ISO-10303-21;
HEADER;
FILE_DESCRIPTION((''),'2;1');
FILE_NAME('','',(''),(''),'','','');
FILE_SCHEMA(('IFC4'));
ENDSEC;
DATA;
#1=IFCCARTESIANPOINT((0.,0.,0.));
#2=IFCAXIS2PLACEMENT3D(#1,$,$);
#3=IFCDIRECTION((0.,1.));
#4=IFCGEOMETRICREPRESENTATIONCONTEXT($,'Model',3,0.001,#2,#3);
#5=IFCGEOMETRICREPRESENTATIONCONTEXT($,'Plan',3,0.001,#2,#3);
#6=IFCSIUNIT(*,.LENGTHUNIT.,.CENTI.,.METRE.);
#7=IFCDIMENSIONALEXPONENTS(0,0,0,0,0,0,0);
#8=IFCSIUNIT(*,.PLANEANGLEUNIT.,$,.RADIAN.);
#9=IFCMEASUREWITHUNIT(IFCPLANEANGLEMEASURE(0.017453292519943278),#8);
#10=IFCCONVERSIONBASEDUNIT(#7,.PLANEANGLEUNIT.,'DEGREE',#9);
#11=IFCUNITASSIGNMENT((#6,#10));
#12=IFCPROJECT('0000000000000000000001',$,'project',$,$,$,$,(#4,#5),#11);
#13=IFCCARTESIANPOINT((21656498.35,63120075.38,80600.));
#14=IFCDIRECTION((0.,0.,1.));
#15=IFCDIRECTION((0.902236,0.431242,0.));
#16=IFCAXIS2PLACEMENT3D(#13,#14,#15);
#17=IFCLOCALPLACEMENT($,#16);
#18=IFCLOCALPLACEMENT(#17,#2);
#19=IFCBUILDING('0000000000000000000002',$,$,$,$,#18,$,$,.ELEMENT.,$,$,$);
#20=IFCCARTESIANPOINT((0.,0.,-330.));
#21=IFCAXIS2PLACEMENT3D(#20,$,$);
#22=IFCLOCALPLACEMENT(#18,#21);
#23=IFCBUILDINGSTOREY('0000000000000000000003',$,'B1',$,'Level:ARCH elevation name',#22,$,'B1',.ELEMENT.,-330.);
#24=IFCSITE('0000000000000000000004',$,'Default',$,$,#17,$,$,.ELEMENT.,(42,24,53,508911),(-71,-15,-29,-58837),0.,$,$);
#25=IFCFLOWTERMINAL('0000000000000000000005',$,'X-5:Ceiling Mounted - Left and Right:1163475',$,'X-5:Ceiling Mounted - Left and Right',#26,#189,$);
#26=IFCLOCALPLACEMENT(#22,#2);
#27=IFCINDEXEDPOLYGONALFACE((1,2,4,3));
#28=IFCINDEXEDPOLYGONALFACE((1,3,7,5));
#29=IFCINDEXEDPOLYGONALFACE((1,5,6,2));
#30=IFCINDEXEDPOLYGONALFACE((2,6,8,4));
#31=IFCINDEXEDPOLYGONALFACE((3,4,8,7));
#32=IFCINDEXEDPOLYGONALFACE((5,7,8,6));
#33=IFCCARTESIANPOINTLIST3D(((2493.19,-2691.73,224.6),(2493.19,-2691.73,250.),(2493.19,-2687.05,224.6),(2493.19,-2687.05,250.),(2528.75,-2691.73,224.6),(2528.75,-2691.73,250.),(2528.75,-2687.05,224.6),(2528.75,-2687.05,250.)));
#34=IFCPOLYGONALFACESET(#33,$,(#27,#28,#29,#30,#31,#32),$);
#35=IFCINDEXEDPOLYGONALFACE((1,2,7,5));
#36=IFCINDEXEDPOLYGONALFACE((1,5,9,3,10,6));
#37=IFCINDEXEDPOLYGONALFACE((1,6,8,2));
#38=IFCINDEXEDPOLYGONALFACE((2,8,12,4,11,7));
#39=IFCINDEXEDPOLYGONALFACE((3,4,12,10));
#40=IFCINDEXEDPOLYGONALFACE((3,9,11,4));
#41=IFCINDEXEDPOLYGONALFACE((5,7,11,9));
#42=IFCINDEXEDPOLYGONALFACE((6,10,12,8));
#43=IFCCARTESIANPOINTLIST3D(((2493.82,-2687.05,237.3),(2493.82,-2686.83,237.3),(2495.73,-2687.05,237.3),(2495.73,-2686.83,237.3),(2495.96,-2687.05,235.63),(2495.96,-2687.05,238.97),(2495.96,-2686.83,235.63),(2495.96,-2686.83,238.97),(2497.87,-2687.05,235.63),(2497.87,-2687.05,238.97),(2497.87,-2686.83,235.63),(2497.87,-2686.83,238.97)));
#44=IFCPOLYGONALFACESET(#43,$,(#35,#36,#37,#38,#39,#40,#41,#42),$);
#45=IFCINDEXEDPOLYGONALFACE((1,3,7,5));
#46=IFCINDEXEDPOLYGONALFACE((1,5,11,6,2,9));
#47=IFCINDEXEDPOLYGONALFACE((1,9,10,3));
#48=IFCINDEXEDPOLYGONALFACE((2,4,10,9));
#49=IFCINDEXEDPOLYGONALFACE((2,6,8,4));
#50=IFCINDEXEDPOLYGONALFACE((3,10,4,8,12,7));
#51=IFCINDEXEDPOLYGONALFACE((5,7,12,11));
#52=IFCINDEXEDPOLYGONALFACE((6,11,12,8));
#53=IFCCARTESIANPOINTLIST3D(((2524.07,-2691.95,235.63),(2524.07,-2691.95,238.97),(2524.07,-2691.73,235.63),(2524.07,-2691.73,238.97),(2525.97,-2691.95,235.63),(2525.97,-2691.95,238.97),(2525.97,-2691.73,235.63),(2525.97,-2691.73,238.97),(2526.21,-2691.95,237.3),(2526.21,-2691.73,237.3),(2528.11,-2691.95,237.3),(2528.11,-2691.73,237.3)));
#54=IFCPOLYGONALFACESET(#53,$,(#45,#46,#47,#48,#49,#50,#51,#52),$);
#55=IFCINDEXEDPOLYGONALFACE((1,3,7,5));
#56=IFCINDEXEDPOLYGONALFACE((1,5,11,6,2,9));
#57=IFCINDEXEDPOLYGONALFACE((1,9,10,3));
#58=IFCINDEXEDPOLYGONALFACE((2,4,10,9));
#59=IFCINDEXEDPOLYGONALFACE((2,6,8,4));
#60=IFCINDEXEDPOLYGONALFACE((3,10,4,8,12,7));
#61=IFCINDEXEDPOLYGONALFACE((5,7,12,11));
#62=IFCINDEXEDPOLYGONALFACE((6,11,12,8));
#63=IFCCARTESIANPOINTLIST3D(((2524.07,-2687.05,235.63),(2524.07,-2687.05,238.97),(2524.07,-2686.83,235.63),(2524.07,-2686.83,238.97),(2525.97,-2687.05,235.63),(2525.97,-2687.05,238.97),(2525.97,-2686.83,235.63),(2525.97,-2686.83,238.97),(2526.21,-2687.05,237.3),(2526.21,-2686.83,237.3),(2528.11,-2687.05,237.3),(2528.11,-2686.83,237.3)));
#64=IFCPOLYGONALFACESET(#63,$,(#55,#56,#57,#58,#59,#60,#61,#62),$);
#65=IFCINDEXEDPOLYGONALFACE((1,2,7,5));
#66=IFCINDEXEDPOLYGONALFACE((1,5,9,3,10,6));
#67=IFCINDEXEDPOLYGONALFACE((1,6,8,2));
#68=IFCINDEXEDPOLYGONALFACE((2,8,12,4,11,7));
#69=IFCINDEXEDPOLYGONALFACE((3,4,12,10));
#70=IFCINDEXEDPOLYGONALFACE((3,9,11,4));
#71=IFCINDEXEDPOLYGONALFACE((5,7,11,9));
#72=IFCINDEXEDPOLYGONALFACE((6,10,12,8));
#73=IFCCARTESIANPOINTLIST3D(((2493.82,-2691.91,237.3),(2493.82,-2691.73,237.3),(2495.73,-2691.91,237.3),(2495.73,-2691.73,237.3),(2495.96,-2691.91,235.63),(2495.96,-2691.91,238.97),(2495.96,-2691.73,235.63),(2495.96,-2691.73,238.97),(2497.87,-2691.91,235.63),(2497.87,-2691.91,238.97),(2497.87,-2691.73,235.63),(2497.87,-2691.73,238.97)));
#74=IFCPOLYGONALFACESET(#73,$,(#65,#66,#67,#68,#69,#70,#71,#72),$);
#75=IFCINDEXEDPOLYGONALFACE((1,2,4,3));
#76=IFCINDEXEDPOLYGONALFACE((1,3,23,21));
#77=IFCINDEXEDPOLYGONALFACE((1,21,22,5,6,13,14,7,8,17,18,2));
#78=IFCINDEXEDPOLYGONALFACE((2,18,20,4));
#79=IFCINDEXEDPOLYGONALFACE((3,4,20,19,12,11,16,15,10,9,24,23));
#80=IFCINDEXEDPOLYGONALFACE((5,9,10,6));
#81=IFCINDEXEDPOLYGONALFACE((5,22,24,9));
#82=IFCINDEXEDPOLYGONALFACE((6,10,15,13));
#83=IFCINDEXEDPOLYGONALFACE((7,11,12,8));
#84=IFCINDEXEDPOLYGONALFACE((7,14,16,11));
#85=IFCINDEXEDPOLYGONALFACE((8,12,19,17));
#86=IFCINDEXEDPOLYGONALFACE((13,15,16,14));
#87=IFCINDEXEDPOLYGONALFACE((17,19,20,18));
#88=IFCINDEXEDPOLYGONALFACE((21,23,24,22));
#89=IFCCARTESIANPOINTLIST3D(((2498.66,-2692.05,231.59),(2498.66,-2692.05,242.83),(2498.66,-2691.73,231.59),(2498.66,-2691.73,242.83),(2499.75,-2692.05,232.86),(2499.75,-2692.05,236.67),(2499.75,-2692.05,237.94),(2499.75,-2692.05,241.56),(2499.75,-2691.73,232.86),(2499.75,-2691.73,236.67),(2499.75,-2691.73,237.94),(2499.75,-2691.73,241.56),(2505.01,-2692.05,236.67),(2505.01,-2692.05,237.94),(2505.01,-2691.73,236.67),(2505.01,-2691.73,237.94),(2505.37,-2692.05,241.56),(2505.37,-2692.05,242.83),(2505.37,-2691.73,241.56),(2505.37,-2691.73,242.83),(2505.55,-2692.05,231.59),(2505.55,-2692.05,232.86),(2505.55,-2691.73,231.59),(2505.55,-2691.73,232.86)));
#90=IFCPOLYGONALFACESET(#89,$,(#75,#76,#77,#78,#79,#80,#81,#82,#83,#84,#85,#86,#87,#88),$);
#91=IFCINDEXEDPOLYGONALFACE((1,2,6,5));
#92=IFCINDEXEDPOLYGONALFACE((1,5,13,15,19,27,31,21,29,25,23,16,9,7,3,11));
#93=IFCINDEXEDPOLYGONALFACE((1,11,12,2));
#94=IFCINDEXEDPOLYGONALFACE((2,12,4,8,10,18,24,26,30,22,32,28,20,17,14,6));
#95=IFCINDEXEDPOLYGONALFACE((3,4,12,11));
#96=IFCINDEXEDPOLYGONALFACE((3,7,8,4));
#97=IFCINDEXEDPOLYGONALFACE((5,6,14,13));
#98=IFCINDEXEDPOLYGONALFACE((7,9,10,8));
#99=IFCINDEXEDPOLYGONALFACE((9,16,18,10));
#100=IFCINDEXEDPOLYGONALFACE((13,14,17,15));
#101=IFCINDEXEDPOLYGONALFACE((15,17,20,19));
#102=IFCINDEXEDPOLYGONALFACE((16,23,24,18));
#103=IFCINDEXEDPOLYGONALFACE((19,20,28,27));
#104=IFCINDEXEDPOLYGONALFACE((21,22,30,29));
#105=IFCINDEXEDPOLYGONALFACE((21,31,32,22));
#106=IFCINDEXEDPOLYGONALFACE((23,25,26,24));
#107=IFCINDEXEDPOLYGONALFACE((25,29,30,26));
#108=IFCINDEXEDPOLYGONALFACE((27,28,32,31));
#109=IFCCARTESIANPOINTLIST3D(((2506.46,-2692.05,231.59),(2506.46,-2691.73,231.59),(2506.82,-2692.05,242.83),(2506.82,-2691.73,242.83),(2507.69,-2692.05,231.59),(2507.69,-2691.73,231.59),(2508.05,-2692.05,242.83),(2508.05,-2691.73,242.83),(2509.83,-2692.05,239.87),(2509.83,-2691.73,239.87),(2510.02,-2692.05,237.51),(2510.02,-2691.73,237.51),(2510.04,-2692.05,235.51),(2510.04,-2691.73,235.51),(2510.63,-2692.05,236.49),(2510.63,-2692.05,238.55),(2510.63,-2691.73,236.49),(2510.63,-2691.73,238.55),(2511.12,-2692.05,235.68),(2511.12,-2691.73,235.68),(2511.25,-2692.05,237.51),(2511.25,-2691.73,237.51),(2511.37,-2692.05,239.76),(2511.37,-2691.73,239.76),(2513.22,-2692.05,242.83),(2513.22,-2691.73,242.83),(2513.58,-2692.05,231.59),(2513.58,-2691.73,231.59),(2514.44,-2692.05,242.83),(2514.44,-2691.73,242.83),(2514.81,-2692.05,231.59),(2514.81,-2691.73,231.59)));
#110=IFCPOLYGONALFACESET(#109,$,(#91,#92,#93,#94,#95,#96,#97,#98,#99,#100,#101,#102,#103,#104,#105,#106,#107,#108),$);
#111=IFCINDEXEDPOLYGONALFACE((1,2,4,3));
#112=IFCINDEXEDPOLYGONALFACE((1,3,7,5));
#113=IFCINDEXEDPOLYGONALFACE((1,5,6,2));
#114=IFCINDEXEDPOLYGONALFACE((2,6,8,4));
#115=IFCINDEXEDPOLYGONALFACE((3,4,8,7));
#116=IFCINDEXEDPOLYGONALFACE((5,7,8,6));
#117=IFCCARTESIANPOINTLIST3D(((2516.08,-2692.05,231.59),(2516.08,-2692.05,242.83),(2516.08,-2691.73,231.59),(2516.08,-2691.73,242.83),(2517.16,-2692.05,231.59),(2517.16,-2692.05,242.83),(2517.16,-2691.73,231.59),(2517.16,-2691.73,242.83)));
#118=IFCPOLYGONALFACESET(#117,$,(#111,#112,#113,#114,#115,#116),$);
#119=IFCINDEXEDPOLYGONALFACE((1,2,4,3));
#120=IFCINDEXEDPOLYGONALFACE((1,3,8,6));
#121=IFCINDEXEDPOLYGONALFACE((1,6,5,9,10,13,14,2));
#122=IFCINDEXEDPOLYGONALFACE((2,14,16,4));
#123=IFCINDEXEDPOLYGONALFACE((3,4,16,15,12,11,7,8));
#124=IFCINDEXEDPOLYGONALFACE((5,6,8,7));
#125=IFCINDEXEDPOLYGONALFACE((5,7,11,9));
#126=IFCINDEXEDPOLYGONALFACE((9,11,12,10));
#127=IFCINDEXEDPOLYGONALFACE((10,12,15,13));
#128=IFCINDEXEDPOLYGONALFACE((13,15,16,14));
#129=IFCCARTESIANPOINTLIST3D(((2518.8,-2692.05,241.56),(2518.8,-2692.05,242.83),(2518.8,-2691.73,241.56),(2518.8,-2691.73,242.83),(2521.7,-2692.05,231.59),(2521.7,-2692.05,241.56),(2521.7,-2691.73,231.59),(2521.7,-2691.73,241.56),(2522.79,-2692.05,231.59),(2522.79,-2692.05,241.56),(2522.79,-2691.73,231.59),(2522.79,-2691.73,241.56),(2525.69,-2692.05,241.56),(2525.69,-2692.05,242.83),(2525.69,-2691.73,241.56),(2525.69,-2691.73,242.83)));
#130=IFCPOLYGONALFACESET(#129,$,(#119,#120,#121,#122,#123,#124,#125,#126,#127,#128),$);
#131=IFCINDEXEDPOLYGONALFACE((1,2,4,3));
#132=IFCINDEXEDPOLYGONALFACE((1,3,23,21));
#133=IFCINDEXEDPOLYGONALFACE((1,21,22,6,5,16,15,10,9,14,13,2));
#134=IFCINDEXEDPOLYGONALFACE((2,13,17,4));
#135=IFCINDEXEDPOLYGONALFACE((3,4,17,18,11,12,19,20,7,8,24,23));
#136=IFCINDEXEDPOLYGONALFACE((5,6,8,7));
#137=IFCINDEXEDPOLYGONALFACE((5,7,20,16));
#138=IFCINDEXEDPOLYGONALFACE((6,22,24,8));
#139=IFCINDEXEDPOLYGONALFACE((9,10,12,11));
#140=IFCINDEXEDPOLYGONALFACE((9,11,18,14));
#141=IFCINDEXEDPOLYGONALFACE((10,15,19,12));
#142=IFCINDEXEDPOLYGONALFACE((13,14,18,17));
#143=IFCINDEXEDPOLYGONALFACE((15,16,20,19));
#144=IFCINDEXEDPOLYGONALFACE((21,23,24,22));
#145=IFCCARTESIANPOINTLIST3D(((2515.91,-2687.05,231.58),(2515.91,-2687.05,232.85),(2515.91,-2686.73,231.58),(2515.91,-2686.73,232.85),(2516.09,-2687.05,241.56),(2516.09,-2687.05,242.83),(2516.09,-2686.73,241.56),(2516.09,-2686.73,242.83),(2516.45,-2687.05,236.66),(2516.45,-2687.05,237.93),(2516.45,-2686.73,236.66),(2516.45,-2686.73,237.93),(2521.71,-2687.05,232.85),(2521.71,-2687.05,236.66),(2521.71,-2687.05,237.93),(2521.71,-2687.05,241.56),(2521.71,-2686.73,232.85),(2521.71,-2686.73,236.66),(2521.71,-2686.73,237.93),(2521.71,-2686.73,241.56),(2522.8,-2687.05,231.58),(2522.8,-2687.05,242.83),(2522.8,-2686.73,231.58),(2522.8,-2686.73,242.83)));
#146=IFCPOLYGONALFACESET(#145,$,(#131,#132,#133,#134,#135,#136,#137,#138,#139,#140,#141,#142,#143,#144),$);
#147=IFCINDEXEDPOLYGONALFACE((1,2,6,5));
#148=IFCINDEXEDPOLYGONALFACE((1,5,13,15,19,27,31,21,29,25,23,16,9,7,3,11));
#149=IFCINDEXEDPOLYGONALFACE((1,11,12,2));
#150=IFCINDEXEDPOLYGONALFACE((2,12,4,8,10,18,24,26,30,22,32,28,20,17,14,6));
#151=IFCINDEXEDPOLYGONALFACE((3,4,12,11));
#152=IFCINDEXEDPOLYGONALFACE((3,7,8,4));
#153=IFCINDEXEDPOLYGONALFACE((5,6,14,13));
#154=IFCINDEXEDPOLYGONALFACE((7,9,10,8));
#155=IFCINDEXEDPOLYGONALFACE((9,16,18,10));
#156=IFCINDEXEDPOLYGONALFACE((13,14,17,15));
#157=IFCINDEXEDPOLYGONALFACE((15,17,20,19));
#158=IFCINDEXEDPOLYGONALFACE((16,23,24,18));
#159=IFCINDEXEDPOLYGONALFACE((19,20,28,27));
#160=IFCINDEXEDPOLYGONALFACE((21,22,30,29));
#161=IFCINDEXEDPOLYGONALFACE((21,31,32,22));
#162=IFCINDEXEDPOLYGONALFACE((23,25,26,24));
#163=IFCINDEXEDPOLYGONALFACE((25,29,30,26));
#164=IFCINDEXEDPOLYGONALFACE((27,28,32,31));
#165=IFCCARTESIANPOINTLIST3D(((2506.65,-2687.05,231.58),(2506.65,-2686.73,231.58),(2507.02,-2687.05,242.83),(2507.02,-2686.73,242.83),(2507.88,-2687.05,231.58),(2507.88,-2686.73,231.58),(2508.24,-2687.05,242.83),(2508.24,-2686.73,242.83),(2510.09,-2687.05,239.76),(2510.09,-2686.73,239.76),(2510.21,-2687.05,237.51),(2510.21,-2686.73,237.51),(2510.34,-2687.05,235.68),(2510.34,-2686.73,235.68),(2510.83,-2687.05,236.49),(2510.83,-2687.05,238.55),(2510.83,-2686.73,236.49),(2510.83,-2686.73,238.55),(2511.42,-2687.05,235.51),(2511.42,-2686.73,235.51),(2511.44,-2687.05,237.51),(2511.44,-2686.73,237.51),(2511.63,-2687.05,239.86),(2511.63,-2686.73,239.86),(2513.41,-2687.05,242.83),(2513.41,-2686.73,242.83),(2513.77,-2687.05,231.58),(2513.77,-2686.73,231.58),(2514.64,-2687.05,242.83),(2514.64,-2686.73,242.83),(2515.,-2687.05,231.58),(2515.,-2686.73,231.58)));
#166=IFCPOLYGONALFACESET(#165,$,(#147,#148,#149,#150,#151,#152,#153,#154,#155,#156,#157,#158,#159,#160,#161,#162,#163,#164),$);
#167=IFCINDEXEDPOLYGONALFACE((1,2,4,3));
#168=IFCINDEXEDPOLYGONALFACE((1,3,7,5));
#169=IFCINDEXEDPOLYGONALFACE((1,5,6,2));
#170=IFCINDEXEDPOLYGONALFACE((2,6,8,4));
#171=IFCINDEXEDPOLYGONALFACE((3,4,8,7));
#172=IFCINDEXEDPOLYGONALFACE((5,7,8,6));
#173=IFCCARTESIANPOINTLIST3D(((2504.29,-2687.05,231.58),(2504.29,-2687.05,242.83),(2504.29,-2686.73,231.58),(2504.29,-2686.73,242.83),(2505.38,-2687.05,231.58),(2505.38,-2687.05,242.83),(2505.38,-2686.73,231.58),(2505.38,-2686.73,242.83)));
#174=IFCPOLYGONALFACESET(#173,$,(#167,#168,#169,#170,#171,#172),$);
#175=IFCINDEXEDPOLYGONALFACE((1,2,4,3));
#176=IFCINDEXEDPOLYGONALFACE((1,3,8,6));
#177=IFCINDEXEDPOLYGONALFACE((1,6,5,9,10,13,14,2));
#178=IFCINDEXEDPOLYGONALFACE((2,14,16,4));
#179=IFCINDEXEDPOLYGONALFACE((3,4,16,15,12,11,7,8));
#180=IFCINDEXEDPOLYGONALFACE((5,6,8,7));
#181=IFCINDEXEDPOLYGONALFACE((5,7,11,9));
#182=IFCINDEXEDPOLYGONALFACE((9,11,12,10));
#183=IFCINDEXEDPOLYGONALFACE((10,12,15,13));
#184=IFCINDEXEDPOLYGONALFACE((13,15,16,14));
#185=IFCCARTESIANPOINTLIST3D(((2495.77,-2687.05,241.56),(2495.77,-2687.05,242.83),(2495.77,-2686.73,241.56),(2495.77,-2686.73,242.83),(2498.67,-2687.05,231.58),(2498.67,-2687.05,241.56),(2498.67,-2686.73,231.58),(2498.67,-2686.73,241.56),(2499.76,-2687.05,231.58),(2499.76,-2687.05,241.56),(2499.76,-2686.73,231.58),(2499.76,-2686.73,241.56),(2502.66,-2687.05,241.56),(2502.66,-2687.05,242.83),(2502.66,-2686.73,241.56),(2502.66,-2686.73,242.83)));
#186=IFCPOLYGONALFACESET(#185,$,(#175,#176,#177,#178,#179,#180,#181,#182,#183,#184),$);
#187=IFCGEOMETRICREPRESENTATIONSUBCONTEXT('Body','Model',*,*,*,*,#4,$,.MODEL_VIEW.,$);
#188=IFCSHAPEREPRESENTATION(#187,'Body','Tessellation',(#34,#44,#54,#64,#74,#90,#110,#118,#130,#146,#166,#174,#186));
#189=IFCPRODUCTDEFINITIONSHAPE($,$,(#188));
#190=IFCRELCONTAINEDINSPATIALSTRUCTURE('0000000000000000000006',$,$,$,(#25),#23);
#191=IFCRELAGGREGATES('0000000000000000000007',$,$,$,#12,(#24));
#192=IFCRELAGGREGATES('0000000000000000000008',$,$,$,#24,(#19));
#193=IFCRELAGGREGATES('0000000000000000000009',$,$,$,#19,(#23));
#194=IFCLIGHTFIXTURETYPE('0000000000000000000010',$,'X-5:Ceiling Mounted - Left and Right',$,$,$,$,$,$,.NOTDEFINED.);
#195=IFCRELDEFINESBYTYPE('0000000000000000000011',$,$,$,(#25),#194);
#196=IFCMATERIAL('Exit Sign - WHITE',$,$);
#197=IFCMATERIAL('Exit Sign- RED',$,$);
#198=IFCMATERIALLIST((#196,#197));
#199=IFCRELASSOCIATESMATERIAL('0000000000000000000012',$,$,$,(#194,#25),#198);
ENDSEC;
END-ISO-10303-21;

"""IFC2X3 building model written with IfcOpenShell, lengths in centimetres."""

from ifc_helpers import new_model, entity, si_unit, converted_unit, direction, frame, frame_2d, origin, place, context, subcontext, project, spatial, polyline, rectangle, outline, extrude, source, transform, mapped, material, material_list, type_object, type_shapes, element, save


model = new_model("IFC2X3")

# Units and contexts
model_context = context("Model", 3, precision=0.001, world=origin(), true_north=direction((0.0, 1.0)))
plan_context = context("Plan", 3, precision=0.001, world=origin(), true_north=direction((0.0, 1.0)))
body_context = subcontext(model_context, "Body", "Model", "MODEL_VIEW")
ifc_project = project(units=[si_unit("LENGTHUNIT", "METRE", prefix="CENTI"), converted_unit("PLANEANGLEUNIT", "DEGREE", entity("IfcPlaneAngleMeasure", 0.017453292519943278), si_unit("PLANEANGLEUNIT", "RADIAN"), dimensions=[0, 0, 0, 0, 0, 0, 0])], contexts=[model_context, plan_context])

# Site, building, storey
site_placement = place(None, frame((21656498.35, 63120075.38, 80600.0), z_axis=(0.0, 0.0, 1.0), x_axis=(0.902236, 0.431242, 0.0)))
site = spatial("IfcSite", under=ifc_project, at=site_placement, Name="Default", CompositionType="ELEMENT", RefLatitude=(42, 24, 53, 508911), RefLongitude=(-71, -15, -29, -58837), RefElevation=0.0)
building_placement = place(site_placement, origin())
building = spatial("IfcBuilding", under=site, at=building_placement, CompositionType="ELEMENT")
storey_placement = place(building_placement, frame((0.0, 0.0, -330.0)))
storey = spatial("IfcBuildingStorey", under=building, at=storey_placement, Name="B1", ObjectType="Level:ARCH elevation name", LongName="B1", CompositionType="ELEMENT", Elevation=-330.0)

# Flow terminal
ifc_material_1 = material(Name="Exit Sign - WHITE")
ifc_material_2 = material(Name="Exit Sign- RED")
ifc_material_list_1 = material_list([ifc_material_1, ifc_material_2])
light_fixture_type_1 = type_object("IfcLightFixtureType", Name="X-5:Ceiling Mounted - Left and Right", PredefinedType="NOTDEFINED", material=ifc_material_list_1)
shared_shape_1 = source(origin(), body_context, "Body", "SweptSolid", [
    extrude(rectangle(XDim=4.68, YDim=35.56, at=frame_2d((0.0, 0.0), x_axis=(1.0, 0.0))), frame((0.0, 1.02, -25.4), z_axis=(0.0, 0.0, 1.0), x_axis=(0.0, 1.0, 0.0)), (0.0, 0.0, 1.0), 25.4),
    extrude(outline(polyline([(-0.24, -1.67), (1.67, -1.67), (-0.47, 0.0), (1.67, 1.67), (-0.24, 1.67), (-2.38, 0.0), (-0.24, -1.67)])), frame((-14.77, 3.36, -12.7), z_axis=(0.0, 1.0, 0.0), x_axis=(1.0, 0.0, 0.0)), (0.0, 0.0, 1.0), 0.22),
    extrude(outline(polyline([(-0.84, -1.47), (1.88, -1.47), (1.22, 1.17), (-0.28, 2.34), (0.37, -0.29), (-2.34, -0.29), (-0.84, -1.47)])), frame((14.77, -1.54, -12.7), z_axis=(0.0, 1.0, 0.0), x_axis=(0.788011, 0.0, -0.615661)), (0.0, 0.0, 1.0), 0.22),
    extrude(outline(polyline([(-0.84, -1.47), (1.88, -1.47), (1.22, 1.17), (-0.28, 2.34), (0.37, -0.29), (-2.34, -0.29), (-0.84, -1.47)])), frame((14.77, 3.36, -12.7), z_axis=(0.0, 1.0, 0.0), x_axis=(0.788011, 0.0, -0.615661)), (0.0, 0.0, 1.0), 0.22),
    extrude(outline(polyline([(-0.24, -1.67), (1.67, -1.67), (-0.47, 0.0), (1.67, 1.67), (-0.24, 1.67), (-2.38, 0.0), (-0.24, -1.67)])), frame((-14.77, -1.49, -12.7), z_axis=(0.0, 1.0, 0.0), x_axis=(1.0, 0.0, 0.0)), (0.0, 0.0, 1.0), 0.18),
    extrude(outline(polyline([(-5.65, -3.69), (5.59, -3.69), (5.59, 3.02), (4.32, 3.02), (4.32, -2.6), (0.7, -2.6), (0.7, 2.66), (-0.57, 2.66), (-0.57, -2.6), (-4.38, -2.6), (-4.38, 3.21), (-5.65, 3.21), (-5.65, -3.69)])), frame((-8.62, -1.63, -12.76), z_axis=(0.0, 1.0, 0.0), x_axis=(0.0, 0.0, 1.0)), (0.0, 0.0, 1.0), 0.32),
    extrude(outline(polyline([(-7.14, 0.57), (-6.5, -0.49), (-1.93, -0.48), (-0.78, -0.48), (-1.23, -1.32), (-3.47, -5.53), (-2.84, -6.59), (0.41, -0.48), (6.62, -0.48), (5.99, 0.57), (2.4, 0.57), (0.98, 0.58), (1.7, 1.94), (3.32, 5.0), (2.69, 6.05), (-0.22, 0.57), (-7.14, 0.57)])), frame((-0.34, -1.63, -12.59), z_axis=(0.0, -1.0, 0.0), x_axis=(0.515099, 0.0, 0.857131)), (0.0, 0.0, -1.0), 0.32),
    extrude(rectangle(XDim=0.32, YDim=1.09, at=frame_2d((0.0, 0.0), x_axis=(1.0, 0.0))), frame((5.65, -1.48, -18.41), z_axis=(0.0, 0.0, 1.0), x_axis=(0.0, 1.0, 0.0)), (0.0, 0.0, 1.0), 11.25),
    extrude(outline(polyline([(-7.8, 0.54), (-7.8, -0.54), (2.18, -0.54), (2.18, -3.45), (3.45, -3.45), (3.45, 3.45), (2.18, 3.45), (2.18, 0.54), (-7.8, 0.54)])), frame((11.28, -1.63, -10.61), z_axis=(0.0, -1.0, 0.0), x_axis=(0.0, 0.0, 1.0)), (0.0, 0.0, -1.0), 0.32),
    extrude(outline(polyline([(-3.69, -5.65), (3.21, -5.65), (3.21, -4.38), (-2.6, -4.38), (-2.6, -0.57), (2.66, -0.57), (2.66, 0.7), (-2.6, 0.7), (-2.6, 4.32), (3.02, 4.32), (3.02, 5.59), (-3.69, 5.59), (-3.69, -5.65)])), frame((8.14, 3.36, -12.76), z_axis=(0.0, 1.0, 0.0), x_axis=(-1.0, 0.0, 0.0)), (0.0, 0.0, 1.0), 0.32),
    extrude(outline(polyline([(-4.16, -5.82), (-2.93, -5.82), (-0.58, -1.9), (0.01, -0.92), (0.5, -1.73), (2.96, -5.82), (4.18, -5.82), (0.62, 0.1), (3.82, 5.42), (2.59, 5.42), (0.75, 2.35), (0.01, 1.14), (-0.79, 2.46), (-2.57, 5.42), (-3.8, 5.42), (-0.6, 0.1), (-4.16, -5.82)])), frame((-0.13, 3.36, -12.59), z_axis=(0.0, 1.0, 0.0), x_axis=(-1.0, 0.0, 0.0)), (0.0, 0.0, 1.0), 0.32),
    extrude(rectangle(XDim=0.32, YDim=1.09, at=frame_2d((0.0, 0.0), x_axis=(1.0, 0.0))), frame((-6.13, 3.52, -18.42), z_axis=(0.0, 0.0, 1.0), x_axis=(0.0, -1.0, 0.0)), (0.0, 0.0, 1.0), 11.25),
    extrude(outline(polyline([(-0.54, -7.8), (0.54, -7.8), (0.54, 2.18), (3.45, 2.18), (3.45, 3.45), (-3.45, 3.45), (-3.45, 2.18), (-0.54, 2.18), (-0.54, -7.8)])), frame((-11.75, 3.36, -10.62), z_axis=(0.0, 1.0, 0.0), x_axis=(-1.0, 0.0, 0.0)), (0.0, 0.0, 1.0), 0.32),
])
type_shapes(light_fixture_type_1, [shared_shape_1])
flow_terminal_placement = place(storey_placement, frame((2510.97, -2690.41, 250.0)))
element("IfcFlowTerminal", 1, at=flow_terminal_placement, inside=storey, type_object=light_fixture_type_1, material=ifc_material_list_1, Name="X-5:Ceiling Mounted - Left and Right:1163475", ObjectType="X-5:Ceiling Mounted - Left and Right", context=body_context, shape_type="MappedRepresentation", body=[
    mapped(shared_shape_1, transform((0.0, 0.0, 0.0), scale=1.0)),
])

save(model, "model.ifc")
